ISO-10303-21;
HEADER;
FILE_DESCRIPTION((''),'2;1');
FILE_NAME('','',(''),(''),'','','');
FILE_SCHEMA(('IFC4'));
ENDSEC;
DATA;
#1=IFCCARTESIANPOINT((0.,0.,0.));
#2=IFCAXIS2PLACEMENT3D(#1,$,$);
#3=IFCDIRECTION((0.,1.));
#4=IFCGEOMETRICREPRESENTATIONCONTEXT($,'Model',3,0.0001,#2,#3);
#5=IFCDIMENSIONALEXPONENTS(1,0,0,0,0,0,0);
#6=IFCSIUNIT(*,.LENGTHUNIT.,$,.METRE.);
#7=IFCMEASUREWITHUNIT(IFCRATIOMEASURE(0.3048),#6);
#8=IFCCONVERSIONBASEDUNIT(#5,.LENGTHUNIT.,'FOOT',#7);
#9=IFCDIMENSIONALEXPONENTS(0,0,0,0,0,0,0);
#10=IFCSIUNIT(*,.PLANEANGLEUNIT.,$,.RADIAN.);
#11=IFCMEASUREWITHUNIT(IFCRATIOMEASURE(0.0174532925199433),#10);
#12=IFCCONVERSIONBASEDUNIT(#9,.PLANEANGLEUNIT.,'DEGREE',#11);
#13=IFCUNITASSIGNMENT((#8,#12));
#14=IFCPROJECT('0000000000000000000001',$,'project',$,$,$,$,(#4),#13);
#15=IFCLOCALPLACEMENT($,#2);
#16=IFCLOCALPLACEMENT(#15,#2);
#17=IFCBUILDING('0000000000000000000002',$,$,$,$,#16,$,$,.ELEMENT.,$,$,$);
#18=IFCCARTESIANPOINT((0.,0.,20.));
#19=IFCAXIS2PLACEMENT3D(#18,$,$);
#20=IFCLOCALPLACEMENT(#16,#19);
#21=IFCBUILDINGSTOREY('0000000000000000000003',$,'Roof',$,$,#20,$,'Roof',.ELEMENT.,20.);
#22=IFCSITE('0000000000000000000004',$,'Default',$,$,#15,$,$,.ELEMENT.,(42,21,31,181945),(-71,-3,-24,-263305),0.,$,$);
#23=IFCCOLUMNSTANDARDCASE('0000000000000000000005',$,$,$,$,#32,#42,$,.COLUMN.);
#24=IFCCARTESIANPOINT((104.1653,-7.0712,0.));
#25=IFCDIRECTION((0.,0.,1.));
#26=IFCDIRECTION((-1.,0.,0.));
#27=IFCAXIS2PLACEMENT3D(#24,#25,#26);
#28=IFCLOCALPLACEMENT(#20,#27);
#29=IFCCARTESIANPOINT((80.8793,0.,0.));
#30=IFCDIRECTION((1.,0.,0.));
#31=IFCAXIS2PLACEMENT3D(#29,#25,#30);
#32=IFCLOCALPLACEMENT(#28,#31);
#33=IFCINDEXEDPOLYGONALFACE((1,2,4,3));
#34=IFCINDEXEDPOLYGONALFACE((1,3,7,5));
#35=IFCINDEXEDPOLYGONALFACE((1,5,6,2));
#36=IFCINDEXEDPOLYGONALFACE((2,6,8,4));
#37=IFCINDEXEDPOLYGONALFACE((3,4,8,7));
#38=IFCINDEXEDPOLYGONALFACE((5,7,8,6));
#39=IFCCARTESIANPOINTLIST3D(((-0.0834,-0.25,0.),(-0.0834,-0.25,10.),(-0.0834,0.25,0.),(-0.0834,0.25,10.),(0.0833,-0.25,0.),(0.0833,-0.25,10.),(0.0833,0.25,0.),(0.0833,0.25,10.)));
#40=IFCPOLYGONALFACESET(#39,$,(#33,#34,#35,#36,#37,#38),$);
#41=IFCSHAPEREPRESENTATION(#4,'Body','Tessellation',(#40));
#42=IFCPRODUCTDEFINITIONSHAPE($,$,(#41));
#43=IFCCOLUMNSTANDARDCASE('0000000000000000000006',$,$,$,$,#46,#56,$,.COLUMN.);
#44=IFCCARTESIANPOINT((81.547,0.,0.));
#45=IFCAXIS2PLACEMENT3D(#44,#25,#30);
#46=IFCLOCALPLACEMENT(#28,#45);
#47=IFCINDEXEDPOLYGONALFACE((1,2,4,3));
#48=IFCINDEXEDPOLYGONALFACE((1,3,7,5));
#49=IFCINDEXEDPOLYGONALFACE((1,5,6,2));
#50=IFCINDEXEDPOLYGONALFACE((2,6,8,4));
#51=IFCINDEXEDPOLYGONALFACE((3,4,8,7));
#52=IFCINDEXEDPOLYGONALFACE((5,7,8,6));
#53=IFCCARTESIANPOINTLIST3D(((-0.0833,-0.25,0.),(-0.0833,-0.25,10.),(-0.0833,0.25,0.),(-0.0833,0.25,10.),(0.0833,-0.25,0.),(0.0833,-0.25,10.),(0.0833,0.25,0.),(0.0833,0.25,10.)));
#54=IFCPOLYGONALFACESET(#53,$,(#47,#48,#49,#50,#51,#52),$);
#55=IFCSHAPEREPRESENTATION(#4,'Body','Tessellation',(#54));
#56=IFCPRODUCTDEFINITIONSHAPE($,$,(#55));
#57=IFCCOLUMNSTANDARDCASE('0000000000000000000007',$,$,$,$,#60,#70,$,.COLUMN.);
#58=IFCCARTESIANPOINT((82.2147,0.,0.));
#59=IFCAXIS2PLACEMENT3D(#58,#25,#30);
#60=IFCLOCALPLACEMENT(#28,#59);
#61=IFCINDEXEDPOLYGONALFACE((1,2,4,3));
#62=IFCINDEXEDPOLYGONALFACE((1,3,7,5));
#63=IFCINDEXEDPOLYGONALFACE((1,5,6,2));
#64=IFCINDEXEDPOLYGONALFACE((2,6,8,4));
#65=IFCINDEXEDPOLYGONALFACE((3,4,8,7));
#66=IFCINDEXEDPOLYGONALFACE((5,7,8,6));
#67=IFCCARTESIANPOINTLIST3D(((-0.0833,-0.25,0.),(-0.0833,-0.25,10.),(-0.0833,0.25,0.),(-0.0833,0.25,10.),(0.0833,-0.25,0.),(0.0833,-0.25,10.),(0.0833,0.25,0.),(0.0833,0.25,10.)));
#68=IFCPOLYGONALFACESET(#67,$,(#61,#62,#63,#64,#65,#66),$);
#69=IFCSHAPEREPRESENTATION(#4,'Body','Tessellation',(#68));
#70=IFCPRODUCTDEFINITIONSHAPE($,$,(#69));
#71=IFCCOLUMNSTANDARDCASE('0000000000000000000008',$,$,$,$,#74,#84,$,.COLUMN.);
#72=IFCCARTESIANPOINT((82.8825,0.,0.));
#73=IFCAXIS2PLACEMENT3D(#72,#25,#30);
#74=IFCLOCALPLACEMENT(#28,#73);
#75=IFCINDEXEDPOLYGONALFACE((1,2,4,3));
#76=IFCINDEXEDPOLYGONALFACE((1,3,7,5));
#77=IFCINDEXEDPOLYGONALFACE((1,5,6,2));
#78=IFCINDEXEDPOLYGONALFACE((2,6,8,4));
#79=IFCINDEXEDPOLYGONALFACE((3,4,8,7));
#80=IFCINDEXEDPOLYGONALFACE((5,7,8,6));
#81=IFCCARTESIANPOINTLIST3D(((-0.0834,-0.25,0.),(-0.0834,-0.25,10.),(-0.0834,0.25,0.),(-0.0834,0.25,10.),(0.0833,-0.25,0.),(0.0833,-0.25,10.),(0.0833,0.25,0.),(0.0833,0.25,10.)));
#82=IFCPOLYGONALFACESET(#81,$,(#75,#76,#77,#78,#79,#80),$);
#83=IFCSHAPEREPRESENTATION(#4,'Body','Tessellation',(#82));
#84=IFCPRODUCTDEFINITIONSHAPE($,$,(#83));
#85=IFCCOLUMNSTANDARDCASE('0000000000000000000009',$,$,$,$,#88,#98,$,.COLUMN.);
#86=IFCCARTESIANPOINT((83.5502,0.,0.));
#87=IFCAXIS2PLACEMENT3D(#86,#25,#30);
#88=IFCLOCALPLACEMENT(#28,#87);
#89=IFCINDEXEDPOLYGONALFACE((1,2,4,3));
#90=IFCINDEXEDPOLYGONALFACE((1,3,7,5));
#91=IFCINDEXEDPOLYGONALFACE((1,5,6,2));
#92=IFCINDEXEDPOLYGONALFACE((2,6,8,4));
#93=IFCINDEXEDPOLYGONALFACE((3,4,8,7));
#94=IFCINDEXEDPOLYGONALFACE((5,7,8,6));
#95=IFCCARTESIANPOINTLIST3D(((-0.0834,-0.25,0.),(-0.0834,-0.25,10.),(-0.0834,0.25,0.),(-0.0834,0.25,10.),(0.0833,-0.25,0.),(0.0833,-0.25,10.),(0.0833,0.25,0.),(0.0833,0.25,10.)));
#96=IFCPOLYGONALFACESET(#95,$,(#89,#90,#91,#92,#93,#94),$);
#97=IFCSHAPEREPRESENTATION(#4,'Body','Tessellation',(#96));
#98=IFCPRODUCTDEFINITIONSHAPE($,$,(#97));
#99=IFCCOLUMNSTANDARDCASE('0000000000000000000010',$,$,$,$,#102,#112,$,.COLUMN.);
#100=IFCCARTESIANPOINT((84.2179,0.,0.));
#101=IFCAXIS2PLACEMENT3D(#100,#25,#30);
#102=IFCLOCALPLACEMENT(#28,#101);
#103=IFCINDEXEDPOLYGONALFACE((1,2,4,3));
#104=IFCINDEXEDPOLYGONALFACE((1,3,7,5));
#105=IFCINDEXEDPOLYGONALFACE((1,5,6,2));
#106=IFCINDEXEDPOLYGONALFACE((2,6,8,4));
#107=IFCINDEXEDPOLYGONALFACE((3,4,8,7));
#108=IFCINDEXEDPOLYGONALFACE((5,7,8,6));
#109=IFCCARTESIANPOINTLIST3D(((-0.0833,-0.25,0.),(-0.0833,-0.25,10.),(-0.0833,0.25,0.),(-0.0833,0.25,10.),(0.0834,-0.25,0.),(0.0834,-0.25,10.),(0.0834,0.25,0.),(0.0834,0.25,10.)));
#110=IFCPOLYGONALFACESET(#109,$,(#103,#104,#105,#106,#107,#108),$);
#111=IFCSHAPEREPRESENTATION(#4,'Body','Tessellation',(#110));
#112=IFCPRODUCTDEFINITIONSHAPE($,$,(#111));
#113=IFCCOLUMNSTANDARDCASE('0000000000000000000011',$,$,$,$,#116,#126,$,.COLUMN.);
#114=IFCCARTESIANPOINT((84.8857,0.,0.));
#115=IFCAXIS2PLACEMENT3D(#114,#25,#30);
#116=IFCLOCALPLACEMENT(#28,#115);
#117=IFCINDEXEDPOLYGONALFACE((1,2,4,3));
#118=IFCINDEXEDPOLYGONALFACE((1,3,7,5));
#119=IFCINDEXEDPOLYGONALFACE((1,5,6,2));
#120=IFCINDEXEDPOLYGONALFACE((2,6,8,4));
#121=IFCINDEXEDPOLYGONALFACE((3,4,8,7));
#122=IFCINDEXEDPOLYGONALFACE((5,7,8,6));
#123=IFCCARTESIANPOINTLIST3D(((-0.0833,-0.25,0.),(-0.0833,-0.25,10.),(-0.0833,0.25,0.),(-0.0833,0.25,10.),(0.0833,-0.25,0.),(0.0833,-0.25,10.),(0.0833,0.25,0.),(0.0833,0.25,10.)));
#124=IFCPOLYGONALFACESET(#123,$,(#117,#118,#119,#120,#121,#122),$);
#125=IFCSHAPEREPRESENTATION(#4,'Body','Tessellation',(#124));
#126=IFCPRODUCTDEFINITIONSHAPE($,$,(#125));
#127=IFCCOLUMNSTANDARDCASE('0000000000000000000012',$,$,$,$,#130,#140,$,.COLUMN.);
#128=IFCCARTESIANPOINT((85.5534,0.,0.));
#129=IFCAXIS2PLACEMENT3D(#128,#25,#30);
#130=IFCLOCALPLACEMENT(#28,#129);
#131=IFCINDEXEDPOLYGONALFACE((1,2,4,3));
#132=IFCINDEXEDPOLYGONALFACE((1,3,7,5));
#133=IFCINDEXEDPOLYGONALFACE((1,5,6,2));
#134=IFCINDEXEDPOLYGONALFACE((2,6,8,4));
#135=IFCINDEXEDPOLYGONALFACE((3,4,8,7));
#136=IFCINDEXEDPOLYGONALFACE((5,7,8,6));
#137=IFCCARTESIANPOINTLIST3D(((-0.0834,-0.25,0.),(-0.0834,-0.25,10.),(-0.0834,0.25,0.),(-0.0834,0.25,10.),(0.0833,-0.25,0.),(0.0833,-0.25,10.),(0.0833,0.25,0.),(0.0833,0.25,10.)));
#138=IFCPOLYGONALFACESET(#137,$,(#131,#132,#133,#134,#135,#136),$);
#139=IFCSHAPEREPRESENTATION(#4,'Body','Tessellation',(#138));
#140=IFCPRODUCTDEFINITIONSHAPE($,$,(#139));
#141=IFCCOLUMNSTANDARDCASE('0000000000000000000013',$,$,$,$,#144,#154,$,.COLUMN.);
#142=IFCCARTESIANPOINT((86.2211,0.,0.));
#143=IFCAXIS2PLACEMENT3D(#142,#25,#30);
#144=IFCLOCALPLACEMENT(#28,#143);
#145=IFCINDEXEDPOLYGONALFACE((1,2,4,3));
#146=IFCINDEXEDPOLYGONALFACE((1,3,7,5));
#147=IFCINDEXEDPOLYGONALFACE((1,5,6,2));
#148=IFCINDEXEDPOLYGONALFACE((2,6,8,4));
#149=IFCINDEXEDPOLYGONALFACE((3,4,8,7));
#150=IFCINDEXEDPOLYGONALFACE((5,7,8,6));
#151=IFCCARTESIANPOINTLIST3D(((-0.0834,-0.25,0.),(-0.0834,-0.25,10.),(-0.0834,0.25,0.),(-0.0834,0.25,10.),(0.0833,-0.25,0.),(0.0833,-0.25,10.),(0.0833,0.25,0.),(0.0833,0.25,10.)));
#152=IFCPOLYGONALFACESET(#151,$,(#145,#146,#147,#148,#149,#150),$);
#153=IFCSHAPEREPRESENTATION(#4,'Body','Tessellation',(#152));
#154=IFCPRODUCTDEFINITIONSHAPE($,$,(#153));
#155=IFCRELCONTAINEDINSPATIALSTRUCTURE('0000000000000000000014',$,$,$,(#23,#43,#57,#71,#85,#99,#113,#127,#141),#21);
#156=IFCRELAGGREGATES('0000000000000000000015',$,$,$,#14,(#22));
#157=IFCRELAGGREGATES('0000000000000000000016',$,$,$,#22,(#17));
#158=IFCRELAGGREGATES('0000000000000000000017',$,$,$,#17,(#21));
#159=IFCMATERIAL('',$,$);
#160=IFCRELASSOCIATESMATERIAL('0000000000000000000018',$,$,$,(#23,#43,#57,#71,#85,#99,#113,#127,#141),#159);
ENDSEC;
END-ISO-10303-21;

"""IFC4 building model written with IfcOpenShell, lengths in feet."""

from ifc_helpers import new_model, entity, si_unit, converted_unit, direction, frame, origin, place, context, project, spatial, rectangle, extrude, material, element, save


model = new_model("IFC4")

# Units and contexts
model_context = context("Model", 3, precision=0.0001, world=origin(), true_north=direction((0.0, 1.0)))
ifc_project = project(units=[converted_unit("LENGTHUNIT", "FOOT", entity("IfcRatioMeasure", 0.3048), si_unit("LENGTHUNIT", "METRE"), dimensions=[1, 0, 0, 0, 0, 0, 0]), converted_unit("PLANEANGLEUNIT", "DEGREE", entity("IfcRatioMeasure", 0.0174532925199433), si_unit("PLANEANGLEUNIT", "RADIAN"), dimensions=[0, 0, 0, 0, 0, 0, 0])], contexts=[model_context])

# Site, building, storey
site_placement = place(None, origin())
site = spatial("IfcSite", under=ifc_project, at=site_placement, Name="Default", CompositionType="ELEMENT", RefLatitude=(42, 21, 31, 181945), RefLongitude=(-71, -3, -24, -263305), RefElevation=0.0)
building_placement = place(site_placement, origin())
building = spatial("IfcBuilding", under=site, at=building_placement, CompositionType="ELEMENT")
storey_placement = place(building_placement, frame((0.0, 0.0, 20.0)))
storey = spatial("IfcBuildingStorey", under=building, at=storey_placement, Name="Roof", LongName="Roof", CompositionType="ELEMENT", Elevation=20.0)

# Columns
ifc_material_1 = material(Name="")
placement = place(storey_placement, frame((104.1653, -7.0712, 0.0), z_axis=(0.0, 0.0, 1.0), x_axis=(-1.0, 0.0, 0.0)))
for number, where, z_axis, x_axis in (
    (1, (80.8793, 0.0, 0.0), (0.0, 0.0, 1.0), (1.0, 0.0, 0.0)),
    (2, (81.547, 0.0, 0.0), (0.0, 0.0, 1.0), (1.0, 0.0, 0.0)),
    (3, (82.2147, 0.0, 0.0), (0.0, 0.0, 1.0), (1.0, 0.0, 0.0)),
    (4, (82.8825, 0.0, 0.0), (0.0, 0.0, 1.0), (1.0, 0.0, 0.0)),
    (5, (83.5502, 0.0, 0.0), (0.0, 0.0, 1.0), (1.0, 0.0, 0.0)),
    (6, (84.2179, 0.0, 0.0), (0.0, 0.0, 1.0), (1.0, 0.0, 0.0)),
    (7, (84.8857, 0.0, 0.0), (0.0, 0.0, 1.0), (1.0, 0.0, 0.0)),
    (8, (85.5534, 0.0, 0.0), (0.0, 0.0, 1.0), (1.0, 0.0, 0.0)),
    (9, (86.2211, 0.0, 0.0), (0.0, 0.0, 1.0), (1.0, 0.0, 0.0)),
):
    element("IfcColumnStandardCase", number, at=place(placement, frame(where, z_axis=z_axis, x_axis=x_axis)), inside=storey, material=ifc_material_1, PredefinedType="COLUMN", context=model_context, shape_type="SweptSolid", body=[
        extrude(rectangle(XDim=0.1667, YDim=0.5), origin(), (0.0, 0.0, 1.0), 10.0),
    ])

save(model, "model.ifc")
